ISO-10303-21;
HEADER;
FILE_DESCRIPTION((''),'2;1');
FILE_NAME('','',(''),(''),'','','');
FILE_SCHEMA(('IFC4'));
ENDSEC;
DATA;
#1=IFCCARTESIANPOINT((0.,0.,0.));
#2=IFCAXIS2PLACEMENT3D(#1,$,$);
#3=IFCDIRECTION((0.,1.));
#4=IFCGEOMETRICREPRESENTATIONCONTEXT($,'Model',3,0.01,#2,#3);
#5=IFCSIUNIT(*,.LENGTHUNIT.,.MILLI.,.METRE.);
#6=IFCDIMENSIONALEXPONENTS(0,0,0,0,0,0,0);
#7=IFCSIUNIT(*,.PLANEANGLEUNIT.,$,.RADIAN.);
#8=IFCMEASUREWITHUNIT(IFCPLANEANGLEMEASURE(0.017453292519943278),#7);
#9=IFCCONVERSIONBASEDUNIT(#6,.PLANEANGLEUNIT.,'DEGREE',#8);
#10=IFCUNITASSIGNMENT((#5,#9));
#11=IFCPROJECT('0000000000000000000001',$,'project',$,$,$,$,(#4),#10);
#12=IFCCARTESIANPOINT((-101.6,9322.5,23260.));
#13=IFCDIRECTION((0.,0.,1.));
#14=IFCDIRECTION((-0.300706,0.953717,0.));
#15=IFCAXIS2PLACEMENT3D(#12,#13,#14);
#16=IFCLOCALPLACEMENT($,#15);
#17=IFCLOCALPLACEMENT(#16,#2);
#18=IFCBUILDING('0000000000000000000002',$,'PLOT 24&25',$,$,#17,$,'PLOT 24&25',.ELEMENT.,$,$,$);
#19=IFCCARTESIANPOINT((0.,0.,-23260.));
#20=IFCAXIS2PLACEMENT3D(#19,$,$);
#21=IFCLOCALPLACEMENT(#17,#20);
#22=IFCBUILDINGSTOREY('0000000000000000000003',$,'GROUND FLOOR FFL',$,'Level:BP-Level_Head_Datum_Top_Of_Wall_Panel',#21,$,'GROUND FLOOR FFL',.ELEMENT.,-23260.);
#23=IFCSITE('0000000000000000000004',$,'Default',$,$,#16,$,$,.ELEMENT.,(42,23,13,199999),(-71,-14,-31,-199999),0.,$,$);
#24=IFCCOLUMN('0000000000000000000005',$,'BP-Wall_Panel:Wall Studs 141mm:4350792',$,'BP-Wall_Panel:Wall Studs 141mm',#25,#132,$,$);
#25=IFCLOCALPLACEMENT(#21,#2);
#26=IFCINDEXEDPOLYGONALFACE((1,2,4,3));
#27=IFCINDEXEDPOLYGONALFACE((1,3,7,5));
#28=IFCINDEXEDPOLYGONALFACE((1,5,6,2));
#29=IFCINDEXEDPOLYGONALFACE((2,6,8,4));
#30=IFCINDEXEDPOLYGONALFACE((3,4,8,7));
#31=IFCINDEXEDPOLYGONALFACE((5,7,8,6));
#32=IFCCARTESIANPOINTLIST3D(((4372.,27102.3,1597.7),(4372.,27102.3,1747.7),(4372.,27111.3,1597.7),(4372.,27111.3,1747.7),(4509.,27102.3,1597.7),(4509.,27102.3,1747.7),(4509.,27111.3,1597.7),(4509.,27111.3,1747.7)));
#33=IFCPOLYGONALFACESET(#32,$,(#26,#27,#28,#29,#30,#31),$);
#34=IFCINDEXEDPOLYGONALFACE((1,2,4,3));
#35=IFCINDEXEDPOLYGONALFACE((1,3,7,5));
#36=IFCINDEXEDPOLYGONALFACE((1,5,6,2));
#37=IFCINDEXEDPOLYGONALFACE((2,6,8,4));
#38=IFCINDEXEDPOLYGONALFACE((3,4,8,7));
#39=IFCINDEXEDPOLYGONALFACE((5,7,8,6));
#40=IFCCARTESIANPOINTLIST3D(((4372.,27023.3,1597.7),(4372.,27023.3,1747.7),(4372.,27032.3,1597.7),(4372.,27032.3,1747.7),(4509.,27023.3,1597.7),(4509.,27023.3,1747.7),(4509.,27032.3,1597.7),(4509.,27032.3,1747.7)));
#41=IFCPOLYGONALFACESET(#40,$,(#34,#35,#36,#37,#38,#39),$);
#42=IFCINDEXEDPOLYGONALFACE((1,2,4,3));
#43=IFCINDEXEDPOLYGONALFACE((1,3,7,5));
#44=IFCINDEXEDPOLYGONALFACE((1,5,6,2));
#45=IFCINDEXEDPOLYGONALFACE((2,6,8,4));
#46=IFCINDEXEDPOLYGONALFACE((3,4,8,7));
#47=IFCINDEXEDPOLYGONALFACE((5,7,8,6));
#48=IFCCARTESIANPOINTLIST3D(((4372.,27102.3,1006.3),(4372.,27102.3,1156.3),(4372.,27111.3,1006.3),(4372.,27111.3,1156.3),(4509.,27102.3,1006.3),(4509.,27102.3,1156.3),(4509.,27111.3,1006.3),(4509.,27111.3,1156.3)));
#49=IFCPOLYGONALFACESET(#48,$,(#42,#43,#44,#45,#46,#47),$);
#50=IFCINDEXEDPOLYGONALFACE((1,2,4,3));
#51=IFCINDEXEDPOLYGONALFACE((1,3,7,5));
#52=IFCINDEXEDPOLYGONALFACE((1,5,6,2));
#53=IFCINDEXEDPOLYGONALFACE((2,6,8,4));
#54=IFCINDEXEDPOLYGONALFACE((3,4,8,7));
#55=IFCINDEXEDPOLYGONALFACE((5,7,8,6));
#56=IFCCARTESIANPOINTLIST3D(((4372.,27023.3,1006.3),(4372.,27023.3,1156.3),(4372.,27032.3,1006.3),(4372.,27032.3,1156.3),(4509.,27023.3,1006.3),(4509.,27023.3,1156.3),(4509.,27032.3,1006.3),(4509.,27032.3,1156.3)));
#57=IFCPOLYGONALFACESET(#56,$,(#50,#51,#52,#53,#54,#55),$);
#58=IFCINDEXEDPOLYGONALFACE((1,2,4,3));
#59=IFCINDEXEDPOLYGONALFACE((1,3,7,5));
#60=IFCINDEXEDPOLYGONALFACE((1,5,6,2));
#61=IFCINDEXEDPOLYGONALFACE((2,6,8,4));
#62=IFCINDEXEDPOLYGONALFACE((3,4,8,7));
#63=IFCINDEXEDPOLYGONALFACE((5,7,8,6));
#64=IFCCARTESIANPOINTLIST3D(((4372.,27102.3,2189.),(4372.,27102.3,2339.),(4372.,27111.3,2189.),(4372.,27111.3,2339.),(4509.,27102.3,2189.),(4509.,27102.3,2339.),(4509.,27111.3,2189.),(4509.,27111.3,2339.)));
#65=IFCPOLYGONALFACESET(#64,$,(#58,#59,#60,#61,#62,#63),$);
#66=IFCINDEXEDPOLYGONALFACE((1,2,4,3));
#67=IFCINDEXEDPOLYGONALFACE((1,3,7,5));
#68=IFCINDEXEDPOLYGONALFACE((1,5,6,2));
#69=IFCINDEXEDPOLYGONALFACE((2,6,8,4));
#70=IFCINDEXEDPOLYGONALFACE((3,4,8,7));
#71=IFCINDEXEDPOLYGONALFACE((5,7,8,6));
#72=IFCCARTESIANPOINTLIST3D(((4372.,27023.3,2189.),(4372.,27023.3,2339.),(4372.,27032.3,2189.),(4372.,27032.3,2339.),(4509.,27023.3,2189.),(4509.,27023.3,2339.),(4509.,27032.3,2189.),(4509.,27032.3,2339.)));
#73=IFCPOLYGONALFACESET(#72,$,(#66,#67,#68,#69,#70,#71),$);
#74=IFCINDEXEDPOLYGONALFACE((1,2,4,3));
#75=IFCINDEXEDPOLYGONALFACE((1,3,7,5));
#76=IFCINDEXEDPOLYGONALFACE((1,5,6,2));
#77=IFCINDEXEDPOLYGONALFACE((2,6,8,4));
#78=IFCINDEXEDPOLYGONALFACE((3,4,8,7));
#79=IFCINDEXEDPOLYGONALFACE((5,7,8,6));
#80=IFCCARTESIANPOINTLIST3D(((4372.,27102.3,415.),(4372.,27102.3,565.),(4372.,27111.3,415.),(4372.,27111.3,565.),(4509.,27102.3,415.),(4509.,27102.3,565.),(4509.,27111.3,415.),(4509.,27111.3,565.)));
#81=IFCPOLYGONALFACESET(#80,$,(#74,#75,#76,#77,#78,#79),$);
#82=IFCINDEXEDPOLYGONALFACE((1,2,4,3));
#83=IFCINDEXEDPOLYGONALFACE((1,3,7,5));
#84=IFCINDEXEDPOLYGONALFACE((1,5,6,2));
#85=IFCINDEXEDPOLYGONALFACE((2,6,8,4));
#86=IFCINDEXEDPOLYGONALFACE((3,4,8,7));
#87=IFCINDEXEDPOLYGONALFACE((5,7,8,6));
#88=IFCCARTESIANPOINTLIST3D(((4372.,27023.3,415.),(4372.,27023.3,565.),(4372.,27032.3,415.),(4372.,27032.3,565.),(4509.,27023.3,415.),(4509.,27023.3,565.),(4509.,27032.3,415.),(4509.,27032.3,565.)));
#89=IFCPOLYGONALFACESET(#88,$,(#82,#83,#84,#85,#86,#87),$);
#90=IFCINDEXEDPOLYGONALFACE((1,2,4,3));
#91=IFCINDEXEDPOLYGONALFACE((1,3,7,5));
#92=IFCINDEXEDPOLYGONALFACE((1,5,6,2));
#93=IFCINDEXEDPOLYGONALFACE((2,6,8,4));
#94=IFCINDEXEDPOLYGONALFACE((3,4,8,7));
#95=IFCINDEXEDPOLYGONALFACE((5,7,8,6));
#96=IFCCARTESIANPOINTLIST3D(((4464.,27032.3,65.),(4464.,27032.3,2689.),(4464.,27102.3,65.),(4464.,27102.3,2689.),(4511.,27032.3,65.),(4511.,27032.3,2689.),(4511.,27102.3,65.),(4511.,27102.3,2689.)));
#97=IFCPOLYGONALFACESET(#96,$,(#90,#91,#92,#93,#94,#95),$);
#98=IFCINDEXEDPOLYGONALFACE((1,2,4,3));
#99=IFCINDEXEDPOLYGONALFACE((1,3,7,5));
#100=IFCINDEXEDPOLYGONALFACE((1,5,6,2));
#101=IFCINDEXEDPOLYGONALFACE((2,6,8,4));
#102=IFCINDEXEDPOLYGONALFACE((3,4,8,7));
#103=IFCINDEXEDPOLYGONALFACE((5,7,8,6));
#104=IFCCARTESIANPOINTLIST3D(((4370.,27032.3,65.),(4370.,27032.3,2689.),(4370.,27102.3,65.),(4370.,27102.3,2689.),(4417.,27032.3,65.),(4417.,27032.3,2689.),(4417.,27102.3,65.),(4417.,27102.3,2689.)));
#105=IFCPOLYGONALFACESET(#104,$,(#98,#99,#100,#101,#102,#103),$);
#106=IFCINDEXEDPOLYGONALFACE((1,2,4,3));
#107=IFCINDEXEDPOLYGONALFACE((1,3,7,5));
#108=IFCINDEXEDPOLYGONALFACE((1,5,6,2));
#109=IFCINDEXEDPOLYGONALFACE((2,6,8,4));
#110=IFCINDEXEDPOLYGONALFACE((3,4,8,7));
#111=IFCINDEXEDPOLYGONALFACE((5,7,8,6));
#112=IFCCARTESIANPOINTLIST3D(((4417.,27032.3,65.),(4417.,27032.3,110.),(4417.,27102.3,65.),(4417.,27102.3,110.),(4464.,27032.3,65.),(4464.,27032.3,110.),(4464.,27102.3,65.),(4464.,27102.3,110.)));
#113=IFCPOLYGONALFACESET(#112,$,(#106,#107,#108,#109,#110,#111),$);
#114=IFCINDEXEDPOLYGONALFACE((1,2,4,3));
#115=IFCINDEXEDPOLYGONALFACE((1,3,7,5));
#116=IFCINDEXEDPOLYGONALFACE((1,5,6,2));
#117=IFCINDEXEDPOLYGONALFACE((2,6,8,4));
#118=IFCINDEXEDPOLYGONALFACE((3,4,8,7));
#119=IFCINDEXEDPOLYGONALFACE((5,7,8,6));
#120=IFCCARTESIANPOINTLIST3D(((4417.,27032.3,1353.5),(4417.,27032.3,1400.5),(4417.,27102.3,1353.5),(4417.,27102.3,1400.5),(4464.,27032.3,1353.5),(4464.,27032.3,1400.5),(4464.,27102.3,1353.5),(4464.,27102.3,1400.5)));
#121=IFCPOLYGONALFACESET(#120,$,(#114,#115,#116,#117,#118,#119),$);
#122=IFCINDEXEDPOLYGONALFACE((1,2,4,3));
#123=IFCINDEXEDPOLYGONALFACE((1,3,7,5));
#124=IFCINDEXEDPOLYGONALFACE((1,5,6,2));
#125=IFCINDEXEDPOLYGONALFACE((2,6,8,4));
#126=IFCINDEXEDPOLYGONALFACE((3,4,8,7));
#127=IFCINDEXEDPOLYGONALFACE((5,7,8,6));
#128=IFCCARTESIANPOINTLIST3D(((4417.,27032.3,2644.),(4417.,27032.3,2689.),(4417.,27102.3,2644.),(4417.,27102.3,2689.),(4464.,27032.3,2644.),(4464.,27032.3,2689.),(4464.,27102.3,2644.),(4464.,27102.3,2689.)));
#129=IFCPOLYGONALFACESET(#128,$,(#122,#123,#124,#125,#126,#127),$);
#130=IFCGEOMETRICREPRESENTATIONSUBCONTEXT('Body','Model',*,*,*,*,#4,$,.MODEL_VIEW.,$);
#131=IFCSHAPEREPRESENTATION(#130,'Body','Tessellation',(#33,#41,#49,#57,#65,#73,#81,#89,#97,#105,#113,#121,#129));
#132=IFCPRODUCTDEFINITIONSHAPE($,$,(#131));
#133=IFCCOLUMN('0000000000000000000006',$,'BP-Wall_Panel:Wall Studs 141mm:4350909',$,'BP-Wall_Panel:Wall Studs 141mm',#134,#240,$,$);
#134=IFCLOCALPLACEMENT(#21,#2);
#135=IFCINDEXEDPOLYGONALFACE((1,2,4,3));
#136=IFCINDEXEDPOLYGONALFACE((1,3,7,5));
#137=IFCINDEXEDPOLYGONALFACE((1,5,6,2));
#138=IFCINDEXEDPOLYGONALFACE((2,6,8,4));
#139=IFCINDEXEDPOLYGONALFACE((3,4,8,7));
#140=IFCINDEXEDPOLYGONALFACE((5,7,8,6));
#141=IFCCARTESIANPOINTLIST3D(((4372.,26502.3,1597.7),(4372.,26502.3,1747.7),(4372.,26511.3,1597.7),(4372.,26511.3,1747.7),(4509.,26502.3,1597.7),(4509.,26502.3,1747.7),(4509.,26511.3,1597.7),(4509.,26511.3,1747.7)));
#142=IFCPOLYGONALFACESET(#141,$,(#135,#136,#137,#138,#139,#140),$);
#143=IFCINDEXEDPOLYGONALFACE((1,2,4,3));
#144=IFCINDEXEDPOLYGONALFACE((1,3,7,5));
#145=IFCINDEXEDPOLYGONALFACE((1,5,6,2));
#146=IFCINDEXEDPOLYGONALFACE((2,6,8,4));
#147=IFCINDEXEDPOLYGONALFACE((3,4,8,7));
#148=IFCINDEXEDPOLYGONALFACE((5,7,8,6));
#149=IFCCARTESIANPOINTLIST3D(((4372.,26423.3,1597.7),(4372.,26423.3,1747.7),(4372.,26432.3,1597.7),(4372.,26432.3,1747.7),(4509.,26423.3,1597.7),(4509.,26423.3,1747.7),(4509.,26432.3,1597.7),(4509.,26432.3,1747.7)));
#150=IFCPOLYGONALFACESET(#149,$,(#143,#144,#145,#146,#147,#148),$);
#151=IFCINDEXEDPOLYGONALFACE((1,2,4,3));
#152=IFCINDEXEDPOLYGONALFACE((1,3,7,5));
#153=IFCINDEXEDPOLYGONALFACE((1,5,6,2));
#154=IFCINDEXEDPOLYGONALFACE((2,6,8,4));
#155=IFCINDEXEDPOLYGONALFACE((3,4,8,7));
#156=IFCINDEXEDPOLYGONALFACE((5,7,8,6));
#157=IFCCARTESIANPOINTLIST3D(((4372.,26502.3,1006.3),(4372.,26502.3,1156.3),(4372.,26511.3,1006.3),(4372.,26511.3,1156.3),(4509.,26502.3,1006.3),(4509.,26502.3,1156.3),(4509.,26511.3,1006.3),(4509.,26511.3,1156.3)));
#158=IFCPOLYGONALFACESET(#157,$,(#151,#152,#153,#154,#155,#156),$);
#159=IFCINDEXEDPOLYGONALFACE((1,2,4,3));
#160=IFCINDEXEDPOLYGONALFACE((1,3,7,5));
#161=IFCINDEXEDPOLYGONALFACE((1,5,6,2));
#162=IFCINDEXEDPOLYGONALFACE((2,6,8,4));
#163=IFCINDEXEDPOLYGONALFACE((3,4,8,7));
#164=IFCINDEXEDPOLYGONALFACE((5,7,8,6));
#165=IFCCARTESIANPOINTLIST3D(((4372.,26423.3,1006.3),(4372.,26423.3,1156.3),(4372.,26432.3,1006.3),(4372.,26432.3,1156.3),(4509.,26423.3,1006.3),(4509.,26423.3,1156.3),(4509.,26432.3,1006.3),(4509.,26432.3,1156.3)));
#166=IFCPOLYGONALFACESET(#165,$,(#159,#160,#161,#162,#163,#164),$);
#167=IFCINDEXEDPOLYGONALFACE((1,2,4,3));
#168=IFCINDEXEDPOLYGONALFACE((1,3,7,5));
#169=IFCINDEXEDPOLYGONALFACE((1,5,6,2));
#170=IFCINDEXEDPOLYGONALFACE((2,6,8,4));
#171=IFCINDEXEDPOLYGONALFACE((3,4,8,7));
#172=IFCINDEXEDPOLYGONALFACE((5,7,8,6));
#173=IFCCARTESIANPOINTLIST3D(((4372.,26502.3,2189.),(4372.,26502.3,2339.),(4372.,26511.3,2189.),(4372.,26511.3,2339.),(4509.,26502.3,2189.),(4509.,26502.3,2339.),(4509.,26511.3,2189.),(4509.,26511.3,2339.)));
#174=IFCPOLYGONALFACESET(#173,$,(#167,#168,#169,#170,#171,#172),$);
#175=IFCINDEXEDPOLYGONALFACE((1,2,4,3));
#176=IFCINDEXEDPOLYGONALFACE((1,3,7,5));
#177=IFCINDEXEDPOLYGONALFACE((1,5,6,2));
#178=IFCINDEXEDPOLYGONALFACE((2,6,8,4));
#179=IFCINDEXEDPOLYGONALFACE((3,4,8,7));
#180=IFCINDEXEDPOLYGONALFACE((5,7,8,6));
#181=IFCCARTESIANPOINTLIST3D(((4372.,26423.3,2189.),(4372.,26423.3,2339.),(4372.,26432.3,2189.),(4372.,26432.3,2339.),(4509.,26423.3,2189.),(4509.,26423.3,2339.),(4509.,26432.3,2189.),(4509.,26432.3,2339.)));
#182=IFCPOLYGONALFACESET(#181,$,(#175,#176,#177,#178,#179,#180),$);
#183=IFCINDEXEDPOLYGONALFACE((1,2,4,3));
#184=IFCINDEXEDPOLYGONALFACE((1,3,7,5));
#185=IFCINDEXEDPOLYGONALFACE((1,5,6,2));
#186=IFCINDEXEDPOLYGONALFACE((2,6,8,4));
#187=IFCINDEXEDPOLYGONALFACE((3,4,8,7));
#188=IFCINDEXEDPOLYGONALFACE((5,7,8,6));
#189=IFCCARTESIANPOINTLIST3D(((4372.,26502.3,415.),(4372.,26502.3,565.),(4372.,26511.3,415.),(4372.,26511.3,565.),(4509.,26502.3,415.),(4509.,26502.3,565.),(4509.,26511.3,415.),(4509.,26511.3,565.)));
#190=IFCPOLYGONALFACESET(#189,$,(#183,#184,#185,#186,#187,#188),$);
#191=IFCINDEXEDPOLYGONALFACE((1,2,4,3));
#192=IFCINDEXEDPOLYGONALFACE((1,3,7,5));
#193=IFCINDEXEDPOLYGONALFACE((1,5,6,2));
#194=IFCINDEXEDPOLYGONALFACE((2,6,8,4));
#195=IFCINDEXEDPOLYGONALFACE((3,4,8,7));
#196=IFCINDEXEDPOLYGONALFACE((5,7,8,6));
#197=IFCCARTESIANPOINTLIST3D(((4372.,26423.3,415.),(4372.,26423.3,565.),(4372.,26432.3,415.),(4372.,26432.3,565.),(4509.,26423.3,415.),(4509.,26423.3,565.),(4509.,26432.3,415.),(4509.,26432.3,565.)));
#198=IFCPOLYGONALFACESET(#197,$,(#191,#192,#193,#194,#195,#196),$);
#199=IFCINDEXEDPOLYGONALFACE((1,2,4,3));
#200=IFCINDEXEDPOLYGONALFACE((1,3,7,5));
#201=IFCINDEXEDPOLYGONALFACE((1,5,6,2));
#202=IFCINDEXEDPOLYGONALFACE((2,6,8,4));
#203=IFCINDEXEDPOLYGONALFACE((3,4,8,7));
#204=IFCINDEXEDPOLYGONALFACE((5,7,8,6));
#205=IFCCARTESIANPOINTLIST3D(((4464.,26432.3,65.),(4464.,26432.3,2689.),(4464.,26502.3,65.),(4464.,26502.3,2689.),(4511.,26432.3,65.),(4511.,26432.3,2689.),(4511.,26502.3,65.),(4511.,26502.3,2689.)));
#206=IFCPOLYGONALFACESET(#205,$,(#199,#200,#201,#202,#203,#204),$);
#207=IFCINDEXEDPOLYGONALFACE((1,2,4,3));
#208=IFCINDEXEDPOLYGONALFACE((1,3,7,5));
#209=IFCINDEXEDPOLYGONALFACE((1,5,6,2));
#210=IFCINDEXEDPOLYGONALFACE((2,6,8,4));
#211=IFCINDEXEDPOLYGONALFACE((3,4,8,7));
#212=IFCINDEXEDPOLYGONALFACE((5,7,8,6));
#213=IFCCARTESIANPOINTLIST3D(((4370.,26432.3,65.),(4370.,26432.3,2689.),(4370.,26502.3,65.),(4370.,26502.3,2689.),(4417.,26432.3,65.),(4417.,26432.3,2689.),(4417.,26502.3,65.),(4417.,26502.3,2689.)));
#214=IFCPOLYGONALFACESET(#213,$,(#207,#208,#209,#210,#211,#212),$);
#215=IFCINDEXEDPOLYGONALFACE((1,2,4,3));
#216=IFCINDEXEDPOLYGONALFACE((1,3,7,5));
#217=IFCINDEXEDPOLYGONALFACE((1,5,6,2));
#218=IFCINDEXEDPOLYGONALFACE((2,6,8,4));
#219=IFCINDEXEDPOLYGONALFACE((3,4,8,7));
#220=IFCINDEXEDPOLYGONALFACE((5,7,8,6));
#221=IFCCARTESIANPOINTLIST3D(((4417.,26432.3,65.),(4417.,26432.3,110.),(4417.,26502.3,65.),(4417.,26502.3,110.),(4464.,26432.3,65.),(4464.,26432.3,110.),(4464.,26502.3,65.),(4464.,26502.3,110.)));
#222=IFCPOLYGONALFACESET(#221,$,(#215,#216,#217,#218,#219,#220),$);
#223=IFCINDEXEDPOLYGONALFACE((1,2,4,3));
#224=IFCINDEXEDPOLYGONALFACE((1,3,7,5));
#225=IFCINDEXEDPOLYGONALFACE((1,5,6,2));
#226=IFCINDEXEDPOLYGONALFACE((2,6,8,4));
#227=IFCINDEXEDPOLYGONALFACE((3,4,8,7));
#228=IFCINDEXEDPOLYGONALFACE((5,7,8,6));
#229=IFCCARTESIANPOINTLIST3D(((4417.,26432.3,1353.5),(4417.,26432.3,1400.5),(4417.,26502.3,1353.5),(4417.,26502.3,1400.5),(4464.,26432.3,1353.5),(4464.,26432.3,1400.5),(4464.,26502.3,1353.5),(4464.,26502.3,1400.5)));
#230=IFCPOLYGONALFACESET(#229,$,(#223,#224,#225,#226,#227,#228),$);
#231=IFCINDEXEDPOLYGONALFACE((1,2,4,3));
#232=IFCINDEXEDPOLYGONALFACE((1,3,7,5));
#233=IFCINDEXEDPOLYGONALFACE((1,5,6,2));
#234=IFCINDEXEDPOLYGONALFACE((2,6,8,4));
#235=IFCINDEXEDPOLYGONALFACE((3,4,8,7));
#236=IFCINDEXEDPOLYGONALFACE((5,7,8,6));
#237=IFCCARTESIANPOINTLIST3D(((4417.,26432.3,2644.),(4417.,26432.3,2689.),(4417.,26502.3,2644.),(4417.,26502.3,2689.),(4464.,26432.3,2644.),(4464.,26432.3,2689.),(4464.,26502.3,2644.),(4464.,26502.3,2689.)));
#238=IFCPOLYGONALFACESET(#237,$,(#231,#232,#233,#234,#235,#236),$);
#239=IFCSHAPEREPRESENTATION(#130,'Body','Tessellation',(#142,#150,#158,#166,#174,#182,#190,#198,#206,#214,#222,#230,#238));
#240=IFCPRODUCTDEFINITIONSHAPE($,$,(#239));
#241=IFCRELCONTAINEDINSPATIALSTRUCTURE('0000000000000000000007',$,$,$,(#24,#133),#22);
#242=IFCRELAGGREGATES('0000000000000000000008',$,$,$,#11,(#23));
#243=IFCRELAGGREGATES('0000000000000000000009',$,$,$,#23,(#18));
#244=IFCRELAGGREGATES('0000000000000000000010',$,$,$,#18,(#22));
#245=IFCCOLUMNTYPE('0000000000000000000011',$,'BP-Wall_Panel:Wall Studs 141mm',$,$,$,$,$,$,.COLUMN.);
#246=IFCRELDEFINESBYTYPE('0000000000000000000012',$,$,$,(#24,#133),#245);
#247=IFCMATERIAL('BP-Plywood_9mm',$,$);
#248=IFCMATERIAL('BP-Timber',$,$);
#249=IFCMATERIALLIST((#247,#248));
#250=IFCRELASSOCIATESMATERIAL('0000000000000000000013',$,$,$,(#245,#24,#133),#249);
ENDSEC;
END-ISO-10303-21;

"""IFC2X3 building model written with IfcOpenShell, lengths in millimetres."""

from ifc_helpers import new_model, entity, si_unit, converted_unit, direction, frame, origin, origin_2d_with_axis, place, context, subcontext, project, spatial, rectangle, extrude, source, transform, mapped, material, material_list, type_object, type_shapes, element, save


model = new_model("IFC2X3")

# Units and contexts
model_context = context("Model", 3, precision=0.01, world=origin(), true_north=direction((0.0, 1.0)))
body_context = subcontext(model_context, "Body", "Model", "MODEL_VIEW")
ifc_project = project(units=[si_unit("LENGTHUNIT", "METRE", prefix="MILLI"), converted_unit("PLANEANGLEUNIT", "DEGREE", entity("IfcPlaneAngleMeasure", 0.017453292519943278), si_unit("PLANEANGLEUNIT", "RADIAN"), dimensions=[0, 0, 0, 0, 0, 0, 0])], contexts=[model_context])

# Site, building, storey
site_placement = place(None, frame((-101.6, 9322.5, 23260.0), z_axis=(0.0, 0.0, 1.0), x_axis=(-0.300706, 0.953717, 0.0)))
site = spatial("IfcSite", under=ifc_project, at=site_placement, Name="Default", CompositionType="ELEMENT", RefLatitude=(42, 23, 13, 199999), RefLongitude=(-71, -14, -31, -199999), RefElevation=0.0)
building_placement = place(site_placement, origin())
building = spatial("IfcBuilding", under=site, at=building_placement, Name="PLOT 24&25", LongName="PLOT 24&25", CompositionType="ELEMENT")
storey_placement = place(building_placement, frame((0.0, 0.0, -23260.0)))
storey = spatial("IfcBuildingStorey", under=building, at=storey_placement, Name="GROUND FLOOR FFL", ObjectType="Level:BP-Level_Head_Datum_Top_Of_Wall_Panel", LongName="GROUND FLOOR FFL", CompositionType="ELEMENT", Elevation=-23260.0)

# Columns
ifc_material_1 = material(Name="BP-Plywood_9mm")
ifc_material_2 = material(Name="BP-Timber")
ifc_material_list = material_list([ifc_material_1, ifc_material_2])
column_type_1 = type_object("IfcColumnType", Name="BP-Wall_Panel:Wall Studs 141mm", PredefinedType="COLUMN", material=ifc_material_list)
shared_shape_1 = source(origin(), body_context, "Body", "SweptSolid", [
    extrude(rectangle(XDim=137.0, YDim=9.0, at=origin_2d_with_axis()), frame((39.5, 0.0, -21662.3), z_axis=(0.0, 0.0, 1.0), x_axis=(0.0, -1.0, 0.0)), (0.0, 0.0, 1.0), 150.0),
    extrude(rectangle(XDim=9.0, YDim=137.0, at=origin_2d_with_axis()), frame((-39.5, 0.0, -21662.3), z_axis=(0.0, 0.0, 1.0), x_axis=(-1.0, 0.0, 0.0)), (0.0, 0.0, 1.0), 150.0),
    extrude(rectangle(XDim=137.0, YDim=9.0, at=origin_2d_with_axis()), frame((39.5, 0.0, -22253.7), z_axis=(0.0, 0.0, 1.0), x_axis=(0.0, -1.0, 0.0)), (0.0, 0.0, 1.0), 150.0),
    extrude(rectangle(XDim=9.0, YDim=137.0, at=origin_2d_with_axis()), frame((-39.5, 0.0, -22253.7), z_axis=(0.0, 0.0, 1.0), x_axis=(-1.0, 0.0, 0.0)), (0.0, 0.0, 1.0), 150.0),
    extrude(rectangle(XDim=137.0, YDim=9.0, at=origin_2d_with_axis()), frame((39.5, 0.0, -21071.0), z_axis=(0.0, 0.0, 1.0), x_axis=(0.0, -1.0, 0.0)), (0.0, 0.0, 1.0), 150.0),
    extrude(rectangle(XDim=9.0, YDim=137.0, at=origin_2d_with_axis()), frame((-39.5, 0.0, -21071.0), z_axis=(0.0, 0.0, 1.0), x_axis=(-1.0, 0.0, 0.0)), (0.0, 0.0, 1.0), 150.0),
    extrude(rectangle(XDim=137.0, YDim=9.0, at=origin_2d_with_axis()), frame((39.5, 0.0, -22845.0), z_axis=(0.0, 0.0, 1.0), x_axis=(0.0, -1.0, 0.0)), (0.0, 0.0, 1.0), 150.0),
    extrude(rectangle(XDim=9.0, YDim=137.0, at=origin_2d_with_axis()), frame((-39.5, 0.0, -22845.0), z_axis=(0.0, 0.0, 1.0), x_axis=(-1.0, 0.0, 0.0)), (0.0, 0.0, 1.0), 150.0),
    extrude(rectangle(XDim=70.0, YDim=47.0, at=origin_2d_with_axis()), frame((0.0, -47.0, -23195.0), z_axis=(0.0, 0.0, 1.0), x_axis=(-1.0, 0.0, 0.0)), (0.0, 0.0, 1.0), 2624.0),
    extrude(rectangle(XDim=70.0, YDim=47.0, at=origin_2d_with_axis()), frame((0.0, 47.0, -23195.0), z_axis=(0.0, 0.0, 1.0), x_axis=(-1.0, 0.0, 0.0)), (0.0, 0.0, 1.0), 2624.0),
    extrude(rectangle(XDim=47.0, YDim=70.0, at=origin_2d_with_axis()), frame((0.0, 0.0, -23195.0), z_axis=(0.0, 0.0, 1.0), x_axis=(0.0, -1.0, 0.0)), (0.0, 0.0, 1.0), 45.0),
    extrude(rectangle(XDim=47.0, YDim=70.0, at=origin_2d_with_axis()), frame((0.0, 0.0, -21906.5), z_axis=(0.0, 0.0, 1.0), x_axis=(0.0, -1.0, 0.0)), (0.0, 0.0, 1.0), 47.0),
    extrude(rectangle(XDim=47.0, YDim=70.0, at=origin_2d_with_axis()), frame((0.0, 0.0, -20616.0), z_axis=(0.0, 0.0, 1.0), x_axis=(0.0, -1.0, 0.0)), (0.0, 0.0, 1.0), 45.0),
])
type_shapes(column_type_1, [shared_shape_1])
for number, where, z_axis, x_axis, name in (
    (1, (4440.5, 27067.3, 23260.0), (0.0, 0.0, 1.0), (0.0, 1.0, 0.0), "BP-Wall_Panel:Wall Studs 141mm:4350792"),
    (2, (4440.5, 26467.3, 23260.0), (0.0, 0.0, 1.0), (0.0, 1.0, 0.0), "BP-Wall_Panel:Wall Studs 141mm:4350909"),
):
    element("IfcColumn", number, at=place(storey_placement, frame(where, z_axis=z_axis, x_axis=x_axis)), inside=storey, type_object=column_type_1, material=ifc_material_list, Name=name, ObjectType="BP-Wall_Panel:Wall Studs 141mm", context=body_context, shape_type="MappedRepresentation", body=[
        mapped(shared_shape_1, transform((0.0, 0.0, 0.0), scale=1.0)),
    ])

save(model, "model.ifc")
